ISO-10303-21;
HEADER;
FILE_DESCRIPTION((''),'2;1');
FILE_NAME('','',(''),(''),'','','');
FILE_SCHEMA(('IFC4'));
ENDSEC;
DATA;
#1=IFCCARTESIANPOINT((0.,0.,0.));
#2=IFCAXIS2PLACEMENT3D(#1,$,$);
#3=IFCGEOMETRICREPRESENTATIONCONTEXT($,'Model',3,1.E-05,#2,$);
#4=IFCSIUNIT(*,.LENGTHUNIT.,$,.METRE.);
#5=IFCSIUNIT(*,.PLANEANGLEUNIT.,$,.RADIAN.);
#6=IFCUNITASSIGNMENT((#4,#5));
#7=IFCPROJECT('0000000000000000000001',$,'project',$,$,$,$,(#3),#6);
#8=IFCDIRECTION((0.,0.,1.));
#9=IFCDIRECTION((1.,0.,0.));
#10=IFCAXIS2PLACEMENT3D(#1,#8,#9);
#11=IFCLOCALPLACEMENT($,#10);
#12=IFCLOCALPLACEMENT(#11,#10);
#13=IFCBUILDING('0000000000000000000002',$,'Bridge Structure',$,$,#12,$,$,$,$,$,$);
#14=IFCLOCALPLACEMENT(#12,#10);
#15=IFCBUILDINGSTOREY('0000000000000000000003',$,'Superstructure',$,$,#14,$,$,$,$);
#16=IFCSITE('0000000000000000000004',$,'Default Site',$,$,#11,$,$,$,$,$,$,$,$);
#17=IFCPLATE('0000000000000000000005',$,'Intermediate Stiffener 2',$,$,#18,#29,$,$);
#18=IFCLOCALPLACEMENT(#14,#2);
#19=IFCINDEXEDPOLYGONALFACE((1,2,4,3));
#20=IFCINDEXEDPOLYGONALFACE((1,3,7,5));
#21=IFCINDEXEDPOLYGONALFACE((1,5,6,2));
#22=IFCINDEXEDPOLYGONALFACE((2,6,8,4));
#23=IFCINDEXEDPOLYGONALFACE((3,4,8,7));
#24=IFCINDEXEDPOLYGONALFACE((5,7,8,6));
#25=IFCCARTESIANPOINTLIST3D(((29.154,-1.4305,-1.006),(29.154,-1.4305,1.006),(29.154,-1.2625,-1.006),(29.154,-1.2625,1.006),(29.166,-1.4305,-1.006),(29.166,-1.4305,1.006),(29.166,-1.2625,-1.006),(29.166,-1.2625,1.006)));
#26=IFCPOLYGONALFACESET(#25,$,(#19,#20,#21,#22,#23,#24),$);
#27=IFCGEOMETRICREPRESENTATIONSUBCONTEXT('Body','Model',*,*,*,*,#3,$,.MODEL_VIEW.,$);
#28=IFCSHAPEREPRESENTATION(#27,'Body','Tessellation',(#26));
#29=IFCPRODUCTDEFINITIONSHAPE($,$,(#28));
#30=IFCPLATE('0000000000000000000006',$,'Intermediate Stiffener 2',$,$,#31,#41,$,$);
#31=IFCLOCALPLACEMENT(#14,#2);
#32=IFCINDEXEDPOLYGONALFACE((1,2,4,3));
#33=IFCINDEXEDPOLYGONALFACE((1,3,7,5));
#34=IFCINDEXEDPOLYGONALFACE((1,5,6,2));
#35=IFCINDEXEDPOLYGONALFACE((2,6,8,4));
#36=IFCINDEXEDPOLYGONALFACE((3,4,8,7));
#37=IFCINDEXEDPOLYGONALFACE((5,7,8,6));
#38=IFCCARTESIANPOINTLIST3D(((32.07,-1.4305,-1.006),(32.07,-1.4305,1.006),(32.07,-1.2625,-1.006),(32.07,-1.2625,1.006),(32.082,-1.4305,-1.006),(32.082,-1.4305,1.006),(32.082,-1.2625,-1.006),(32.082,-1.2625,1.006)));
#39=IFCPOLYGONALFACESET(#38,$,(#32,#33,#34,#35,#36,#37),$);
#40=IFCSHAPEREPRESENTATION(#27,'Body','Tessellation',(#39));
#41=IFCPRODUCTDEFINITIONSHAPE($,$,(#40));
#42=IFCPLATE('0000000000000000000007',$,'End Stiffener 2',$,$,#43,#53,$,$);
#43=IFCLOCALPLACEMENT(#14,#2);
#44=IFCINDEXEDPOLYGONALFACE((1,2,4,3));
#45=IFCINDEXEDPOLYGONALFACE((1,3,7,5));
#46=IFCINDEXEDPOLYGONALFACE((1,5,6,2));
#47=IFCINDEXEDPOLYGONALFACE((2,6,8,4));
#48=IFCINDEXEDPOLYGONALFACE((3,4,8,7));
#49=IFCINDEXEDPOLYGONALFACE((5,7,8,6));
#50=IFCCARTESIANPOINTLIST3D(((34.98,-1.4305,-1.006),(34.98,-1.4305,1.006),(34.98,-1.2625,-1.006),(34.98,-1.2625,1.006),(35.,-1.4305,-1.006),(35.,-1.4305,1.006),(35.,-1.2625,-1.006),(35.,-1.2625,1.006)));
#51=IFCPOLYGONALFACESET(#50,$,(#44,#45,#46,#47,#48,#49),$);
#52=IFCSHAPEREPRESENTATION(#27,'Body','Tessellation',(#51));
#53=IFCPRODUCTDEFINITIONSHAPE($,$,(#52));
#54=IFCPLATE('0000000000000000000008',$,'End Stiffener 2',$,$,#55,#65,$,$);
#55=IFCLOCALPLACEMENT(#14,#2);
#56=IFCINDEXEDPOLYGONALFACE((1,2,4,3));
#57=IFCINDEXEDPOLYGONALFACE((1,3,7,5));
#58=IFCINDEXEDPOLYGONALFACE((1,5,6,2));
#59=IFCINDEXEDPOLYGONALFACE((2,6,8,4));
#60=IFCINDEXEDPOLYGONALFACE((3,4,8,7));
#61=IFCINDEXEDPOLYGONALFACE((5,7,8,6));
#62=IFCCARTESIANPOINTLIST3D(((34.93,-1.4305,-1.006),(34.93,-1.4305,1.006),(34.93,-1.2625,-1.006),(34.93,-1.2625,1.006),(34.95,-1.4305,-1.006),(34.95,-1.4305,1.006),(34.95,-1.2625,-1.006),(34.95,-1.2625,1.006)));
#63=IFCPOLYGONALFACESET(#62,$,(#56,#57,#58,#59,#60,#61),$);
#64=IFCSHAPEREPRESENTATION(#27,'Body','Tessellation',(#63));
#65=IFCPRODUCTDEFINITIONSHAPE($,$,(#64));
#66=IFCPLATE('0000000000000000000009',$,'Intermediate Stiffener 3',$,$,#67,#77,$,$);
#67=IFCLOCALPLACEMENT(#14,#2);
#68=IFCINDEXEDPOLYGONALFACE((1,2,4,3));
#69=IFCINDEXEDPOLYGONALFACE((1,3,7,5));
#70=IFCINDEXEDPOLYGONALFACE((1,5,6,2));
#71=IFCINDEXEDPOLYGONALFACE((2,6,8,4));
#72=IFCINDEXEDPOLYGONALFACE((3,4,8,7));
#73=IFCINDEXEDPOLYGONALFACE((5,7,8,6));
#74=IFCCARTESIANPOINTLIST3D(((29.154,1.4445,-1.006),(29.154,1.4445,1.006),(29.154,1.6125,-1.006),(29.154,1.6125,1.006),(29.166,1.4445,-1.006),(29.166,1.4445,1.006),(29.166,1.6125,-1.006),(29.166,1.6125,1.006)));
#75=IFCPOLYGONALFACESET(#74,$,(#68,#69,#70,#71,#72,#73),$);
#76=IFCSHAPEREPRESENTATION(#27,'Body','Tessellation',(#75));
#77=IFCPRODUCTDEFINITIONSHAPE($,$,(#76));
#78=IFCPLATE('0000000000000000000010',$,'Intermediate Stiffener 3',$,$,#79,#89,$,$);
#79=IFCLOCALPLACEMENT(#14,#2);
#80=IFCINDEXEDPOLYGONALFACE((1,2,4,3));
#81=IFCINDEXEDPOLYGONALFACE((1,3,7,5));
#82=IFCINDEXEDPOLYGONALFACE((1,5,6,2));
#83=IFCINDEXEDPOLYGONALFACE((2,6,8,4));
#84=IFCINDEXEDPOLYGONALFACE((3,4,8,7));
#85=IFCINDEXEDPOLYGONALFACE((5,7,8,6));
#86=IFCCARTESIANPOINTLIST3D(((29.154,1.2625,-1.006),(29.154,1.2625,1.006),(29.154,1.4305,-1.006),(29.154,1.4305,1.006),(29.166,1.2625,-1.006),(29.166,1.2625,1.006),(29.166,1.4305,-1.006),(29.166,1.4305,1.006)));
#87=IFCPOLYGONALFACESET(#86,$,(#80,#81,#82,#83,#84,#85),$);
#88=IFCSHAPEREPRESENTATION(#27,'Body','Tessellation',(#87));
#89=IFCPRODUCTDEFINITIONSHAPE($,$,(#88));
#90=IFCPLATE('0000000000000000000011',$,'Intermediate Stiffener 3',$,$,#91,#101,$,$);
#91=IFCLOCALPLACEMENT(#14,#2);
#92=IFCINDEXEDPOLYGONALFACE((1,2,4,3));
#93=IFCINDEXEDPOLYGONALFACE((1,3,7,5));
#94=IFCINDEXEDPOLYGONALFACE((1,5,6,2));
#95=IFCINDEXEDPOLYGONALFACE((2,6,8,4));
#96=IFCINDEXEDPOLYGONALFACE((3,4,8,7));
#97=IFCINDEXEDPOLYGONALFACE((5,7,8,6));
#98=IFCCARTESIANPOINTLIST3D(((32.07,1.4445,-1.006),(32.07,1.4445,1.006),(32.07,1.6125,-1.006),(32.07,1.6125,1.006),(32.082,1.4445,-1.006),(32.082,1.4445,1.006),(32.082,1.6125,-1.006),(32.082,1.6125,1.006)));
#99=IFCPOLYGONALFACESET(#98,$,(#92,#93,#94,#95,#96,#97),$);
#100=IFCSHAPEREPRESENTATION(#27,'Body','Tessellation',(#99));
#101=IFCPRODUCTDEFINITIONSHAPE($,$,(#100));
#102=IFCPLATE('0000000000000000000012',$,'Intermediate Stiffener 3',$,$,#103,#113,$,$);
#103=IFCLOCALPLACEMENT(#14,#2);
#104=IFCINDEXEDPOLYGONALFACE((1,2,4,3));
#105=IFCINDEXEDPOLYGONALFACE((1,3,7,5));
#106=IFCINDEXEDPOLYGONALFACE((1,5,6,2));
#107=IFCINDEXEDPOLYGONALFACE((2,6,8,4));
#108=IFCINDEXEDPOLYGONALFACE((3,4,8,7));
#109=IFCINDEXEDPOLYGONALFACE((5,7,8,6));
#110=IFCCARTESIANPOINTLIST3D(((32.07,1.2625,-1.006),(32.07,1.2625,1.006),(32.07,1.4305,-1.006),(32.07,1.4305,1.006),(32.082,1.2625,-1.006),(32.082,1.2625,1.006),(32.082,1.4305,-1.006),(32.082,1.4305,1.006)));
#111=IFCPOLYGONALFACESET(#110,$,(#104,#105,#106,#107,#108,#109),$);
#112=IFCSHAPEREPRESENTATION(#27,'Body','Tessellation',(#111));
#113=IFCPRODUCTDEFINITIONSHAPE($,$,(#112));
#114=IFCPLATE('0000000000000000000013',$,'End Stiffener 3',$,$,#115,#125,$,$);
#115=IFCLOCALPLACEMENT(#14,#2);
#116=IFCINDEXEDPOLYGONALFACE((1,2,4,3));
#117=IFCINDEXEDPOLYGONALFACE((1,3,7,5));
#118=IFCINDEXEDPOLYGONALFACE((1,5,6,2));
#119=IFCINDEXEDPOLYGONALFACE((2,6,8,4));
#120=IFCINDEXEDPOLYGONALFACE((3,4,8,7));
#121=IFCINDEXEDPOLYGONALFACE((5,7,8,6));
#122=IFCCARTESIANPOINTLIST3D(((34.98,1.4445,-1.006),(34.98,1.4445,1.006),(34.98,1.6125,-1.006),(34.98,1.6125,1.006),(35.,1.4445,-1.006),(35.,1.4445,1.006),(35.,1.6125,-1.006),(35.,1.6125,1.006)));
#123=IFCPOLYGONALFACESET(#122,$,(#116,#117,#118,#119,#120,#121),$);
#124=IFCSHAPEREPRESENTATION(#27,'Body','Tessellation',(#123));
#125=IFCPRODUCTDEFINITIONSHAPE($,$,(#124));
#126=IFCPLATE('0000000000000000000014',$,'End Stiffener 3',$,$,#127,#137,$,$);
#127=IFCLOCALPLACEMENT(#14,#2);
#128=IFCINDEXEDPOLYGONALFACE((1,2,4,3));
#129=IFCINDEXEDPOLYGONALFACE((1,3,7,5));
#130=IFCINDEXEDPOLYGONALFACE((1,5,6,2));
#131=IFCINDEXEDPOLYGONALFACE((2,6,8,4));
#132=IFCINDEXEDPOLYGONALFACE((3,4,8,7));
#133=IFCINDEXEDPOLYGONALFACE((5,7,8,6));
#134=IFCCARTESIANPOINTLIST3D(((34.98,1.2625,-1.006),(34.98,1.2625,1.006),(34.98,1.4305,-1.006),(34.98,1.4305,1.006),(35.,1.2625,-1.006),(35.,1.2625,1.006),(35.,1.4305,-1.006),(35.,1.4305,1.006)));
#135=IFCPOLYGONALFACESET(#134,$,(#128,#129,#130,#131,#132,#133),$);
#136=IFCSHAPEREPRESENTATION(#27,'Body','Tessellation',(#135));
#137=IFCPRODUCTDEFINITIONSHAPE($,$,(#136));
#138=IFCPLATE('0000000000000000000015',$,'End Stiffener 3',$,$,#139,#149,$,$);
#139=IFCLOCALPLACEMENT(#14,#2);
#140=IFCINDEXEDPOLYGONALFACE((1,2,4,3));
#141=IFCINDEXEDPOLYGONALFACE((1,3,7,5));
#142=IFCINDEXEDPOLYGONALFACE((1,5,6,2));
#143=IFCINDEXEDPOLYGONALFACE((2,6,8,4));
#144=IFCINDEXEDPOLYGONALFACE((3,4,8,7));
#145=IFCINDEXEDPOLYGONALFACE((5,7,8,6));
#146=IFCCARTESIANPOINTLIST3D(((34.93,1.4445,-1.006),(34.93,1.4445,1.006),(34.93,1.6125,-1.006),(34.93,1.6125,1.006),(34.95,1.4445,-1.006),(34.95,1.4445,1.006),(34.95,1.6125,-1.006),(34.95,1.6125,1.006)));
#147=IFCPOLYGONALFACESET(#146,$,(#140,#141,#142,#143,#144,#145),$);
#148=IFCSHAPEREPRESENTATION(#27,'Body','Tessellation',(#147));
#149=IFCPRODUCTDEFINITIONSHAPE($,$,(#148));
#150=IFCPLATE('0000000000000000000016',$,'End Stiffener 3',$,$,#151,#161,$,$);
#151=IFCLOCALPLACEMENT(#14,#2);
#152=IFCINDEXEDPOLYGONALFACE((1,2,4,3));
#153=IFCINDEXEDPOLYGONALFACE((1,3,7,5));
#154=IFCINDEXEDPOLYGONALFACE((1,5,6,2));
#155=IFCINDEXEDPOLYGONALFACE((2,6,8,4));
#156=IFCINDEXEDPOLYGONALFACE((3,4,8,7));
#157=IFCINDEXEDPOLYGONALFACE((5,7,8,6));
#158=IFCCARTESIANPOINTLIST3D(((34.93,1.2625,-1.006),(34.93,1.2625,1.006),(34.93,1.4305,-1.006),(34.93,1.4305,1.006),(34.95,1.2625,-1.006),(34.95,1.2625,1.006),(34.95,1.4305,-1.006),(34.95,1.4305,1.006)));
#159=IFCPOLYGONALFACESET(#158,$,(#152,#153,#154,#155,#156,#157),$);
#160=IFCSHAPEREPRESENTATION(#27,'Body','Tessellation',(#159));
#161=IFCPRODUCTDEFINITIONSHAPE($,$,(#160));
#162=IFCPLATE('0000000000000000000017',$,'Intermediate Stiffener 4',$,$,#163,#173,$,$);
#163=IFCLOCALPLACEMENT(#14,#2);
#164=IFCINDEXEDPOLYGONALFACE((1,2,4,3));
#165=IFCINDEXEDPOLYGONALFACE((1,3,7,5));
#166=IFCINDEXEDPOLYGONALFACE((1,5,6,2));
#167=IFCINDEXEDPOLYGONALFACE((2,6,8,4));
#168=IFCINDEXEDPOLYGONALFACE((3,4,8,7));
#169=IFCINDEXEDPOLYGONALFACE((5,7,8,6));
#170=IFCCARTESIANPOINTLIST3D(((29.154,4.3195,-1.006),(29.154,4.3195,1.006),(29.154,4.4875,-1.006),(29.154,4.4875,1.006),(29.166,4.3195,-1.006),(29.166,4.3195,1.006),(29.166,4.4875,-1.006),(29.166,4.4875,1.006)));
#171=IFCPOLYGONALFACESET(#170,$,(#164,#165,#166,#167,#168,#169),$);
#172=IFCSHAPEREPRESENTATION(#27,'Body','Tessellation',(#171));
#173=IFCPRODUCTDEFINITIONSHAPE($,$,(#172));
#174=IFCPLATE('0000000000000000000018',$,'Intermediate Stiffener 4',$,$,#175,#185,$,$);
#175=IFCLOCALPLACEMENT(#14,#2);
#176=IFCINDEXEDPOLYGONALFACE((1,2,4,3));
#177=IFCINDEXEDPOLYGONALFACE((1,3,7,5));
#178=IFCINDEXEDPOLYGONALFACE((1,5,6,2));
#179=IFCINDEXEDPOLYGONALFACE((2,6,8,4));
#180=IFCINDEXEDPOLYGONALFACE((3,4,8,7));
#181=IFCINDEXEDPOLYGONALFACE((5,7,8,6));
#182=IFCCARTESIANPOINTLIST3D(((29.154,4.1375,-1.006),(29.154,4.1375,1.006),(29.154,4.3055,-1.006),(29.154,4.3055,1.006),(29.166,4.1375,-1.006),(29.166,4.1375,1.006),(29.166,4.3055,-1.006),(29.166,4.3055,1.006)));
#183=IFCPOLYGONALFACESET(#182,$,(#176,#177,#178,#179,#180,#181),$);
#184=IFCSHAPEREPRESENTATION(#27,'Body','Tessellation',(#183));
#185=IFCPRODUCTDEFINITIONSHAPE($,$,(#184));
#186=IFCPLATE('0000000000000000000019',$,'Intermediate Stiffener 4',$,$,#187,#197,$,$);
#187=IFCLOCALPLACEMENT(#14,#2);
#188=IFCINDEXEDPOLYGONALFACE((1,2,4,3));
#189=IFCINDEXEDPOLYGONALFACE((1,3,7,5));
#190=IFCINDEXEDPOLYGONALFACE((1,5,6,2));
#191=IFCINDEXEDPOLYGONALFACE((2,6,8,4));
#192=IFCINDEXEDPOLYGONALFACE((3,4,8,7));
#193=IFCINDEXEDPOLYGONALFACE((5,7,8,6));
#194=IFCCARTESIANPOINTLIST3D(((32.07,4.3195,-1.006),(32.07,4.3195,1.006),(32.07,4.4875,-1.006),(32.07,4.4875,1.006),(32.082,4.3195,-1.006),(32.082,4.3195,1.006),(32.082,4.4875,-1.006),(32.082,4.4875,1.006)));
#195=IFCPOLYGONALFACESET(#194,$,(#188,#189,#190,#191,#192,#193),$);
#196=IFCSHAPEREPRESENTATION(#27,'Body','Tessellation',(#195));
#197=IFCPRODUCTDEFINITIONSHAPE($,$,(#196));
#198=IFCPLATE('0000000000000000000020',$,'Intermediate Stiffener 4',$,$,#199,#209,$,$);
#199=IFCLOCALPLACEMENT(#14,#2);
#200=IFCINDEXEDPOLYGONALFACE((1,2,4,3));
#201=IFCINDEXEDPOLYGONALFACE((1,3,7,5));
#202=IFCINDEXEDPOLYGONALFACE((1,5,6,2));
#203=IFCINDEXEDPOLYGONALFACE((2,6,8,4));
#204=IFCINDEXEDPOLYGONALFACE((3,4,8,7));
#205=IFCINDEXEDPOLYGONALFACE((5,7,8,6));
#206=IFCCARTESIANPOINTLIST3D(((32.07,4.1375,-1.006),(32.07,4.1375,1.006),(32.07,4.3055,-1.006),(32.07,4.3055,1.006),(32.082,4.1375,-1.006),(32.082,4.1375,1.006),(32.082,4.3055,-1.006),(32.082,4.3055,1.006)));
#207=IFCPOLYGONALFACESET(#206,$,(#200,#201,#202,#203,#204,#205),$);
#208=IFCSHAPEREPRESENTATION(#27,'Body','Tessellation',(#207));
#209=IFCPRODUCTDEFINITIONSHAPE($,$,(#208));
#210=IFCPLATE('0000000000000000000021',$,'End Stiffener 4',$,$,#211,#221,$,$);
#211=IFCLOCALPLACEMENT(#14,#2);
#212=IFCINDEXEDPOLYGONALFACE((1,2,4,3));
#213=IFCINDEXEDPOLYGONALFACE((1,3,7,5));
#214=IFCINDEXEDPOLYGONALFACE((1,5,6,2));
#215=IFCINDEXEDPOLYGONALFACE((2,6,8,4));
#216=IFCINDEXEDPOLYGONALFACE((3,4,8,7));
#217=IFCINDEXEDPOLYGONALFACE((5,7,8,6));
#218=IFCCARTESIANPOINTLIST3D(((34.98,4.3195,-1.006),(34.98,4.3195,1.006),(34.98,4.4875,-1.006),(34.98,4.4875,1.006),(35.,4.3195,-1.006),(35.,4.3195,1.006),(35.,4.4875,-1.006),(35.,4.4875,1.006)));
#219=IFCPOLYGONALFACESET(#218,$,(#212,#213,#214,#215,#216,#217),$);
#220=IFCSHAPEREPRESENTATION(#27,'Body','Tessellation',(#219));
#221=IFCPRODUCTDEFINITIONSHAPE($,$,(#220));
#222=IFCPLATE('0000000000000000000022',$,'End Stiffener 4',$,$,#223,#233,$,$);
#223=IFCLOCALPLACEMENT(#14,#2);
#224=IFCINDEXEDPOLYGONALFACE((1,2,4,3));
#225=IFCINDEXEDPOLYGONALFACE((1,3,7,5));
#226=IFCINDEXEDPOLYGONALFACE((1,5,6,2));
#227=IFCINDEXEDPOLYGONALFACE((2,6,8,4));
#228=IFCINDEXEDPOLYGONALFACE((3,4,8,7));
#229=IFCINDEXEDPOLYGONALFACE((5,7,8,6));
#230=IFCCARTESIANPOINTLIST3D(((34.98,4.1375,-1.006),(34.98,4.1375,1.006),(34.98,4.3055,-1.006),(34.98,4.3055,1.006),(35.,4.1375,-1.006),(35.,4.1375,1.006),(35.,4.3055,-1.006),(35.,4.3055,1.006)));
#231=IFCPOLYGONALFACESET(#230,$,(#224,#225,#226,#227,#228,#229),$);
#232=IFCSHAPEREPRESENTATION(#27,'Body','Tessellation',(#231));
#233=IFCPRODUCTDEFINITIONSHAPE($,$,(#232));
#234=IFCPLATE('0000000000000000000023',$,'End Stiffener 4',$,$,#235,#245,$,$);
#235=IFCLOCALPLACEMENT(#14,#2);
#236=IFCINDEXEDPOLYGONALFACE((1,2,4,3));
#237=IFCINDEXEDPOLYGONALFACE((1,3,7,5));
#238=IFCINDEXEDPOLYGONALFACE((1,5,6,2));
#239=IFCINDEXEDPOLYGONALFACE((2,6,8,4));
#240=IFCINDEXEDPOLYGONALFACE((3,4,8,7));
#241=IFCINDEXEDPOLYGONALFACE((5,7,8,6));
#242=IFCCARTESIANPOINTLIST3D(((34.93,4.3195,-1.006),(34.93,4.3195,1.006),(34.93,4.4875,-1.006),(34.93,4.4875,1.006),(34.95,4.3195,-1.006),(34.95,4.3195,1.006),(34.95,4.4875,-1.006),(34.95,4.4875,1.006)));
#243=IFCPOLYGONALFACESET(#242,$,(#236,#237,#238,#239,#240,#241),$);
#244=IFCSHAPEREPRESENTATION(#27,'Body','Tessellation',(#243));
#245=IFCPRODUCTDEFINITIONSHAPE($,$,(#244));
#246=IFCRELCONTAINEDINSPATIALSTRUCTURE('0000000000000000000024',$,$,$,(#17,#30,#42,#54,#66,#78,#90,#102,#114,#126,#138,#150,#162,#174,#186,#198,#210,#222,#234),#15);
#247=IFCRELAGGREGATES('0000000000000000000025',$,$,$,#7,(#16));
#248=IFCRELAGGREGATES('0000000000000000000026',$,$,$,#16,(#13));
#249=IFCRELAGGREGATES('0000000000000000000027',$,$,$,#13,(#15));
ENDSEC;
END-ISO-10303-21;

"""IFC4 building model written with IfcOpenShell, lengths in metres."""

from ifc_helpers import new_model, si_unit, frame, origin, origin_with_axes, origin_2d_with_axis, place, context, subcontext, project, spatial, rectangle, extrude, element, save


model = new_model("IFC4")

# Units and contexts
model_context = context("Model", 3, precision=1e-05, world=origin())
body_context = subcontext(model_context, "Body", "Model", "MODEL_VIEW")
ifc_project = project(units=[si_unit("LENGTHUNIT", "METRE"), si_unit("PLANEANGLEUNIT", "RADIAN")], contexts=[model_context])

# Site, building, storey
site_placement = place(None, origin_with_axes())
site = spatial("IfcSite", under=ifc_project, at=site_placement, Name="Default Site")
building_placement = place(site_placement, origin_with_axes())
building = spatial("IfcBuilding", under=site, at=building_placement, Name="Bridge Structure")
storey_placement = place(building_placement, origin_with_axes())
storey = spatial("IfcBuildingStorey", under=building, at=storey_placement, Name="Superstructure")

# Plates
for number, where, z_axis, x_axis, name in (
    (1, (29.16, -1.3465, -1.006), (0.0, 0.0, 1.0), (1.0, 0.0, 0.0), "Intermediate Stiffener 2"),
    (2, (32.076, -1.3465, -1.006), (0.0, 0.0, 1.0), (1.0, 0.0, 0.0), "Intermediate Stiffener 2"),
):
    element("IfcPlate", number, at=place(storey_placement, frame(where, z_axis=z_axis, x_axis=x_axis)), inside=storey, Name=name, context=body_context, shape_type="SweptSolid", body=[
        extrude(rectangle(XDim=0.012, YDim=0.168, at=origin_2d_with_axis()), origin_with_axes(), (0.0, 0.0, 1.0), 2.012),
    ])
for number, where, z_axis, x_axis, name in (
    (3, (34.99, -1.3465, -1.006), (0.0, 0.0, 1.0), (1.0, 0.0, 0.0), "End Stiffener 2"),
    (4, (34.94, -1.3465, -1.006), (0.0, 0.0, 1.0), (1.0, 0.0, 0.0), "End Stiffener 2"),
):
    element("IfcPlate", number, at=place(storey_placement, frame(where, z_axis=z_axis, x_axis=x_axis)), inside=storey, Name=name, context=body_context, shape_type="SweptSolid", body=[
        extrude(rectangle(XDim=0.02, YDim=0.168, at=origin_2d_with_axis()), origin_with_axes(), (0.0, 0.0, 1.0), 2.012),
    ])
for number, where, z_axis, x_axis, name in (
    (5, (29.16, 1.5285, -1.006), (0.0, 0.0, 1.0), (1.0, 0.0, 0.0), "Intermediate Stiffener 3"),
    (6, (29.16, 1.3465, -1.006), (0.0, 0.0, 1.0), (1.0, 0.0, 0.0), "Intermediate Stiffener 3"),
    (7, (32.076, 1.5285, -1.006), (0.0, 0.0, 1.0), (1.0, 0.0, 0.0), "Intermediate Stiffener 3"),
    (8, (32.076, 1.3465, -1.006), (0.0, 0.0, 1.0), (1.0, 0.0, 0.0), "Intermediate Stiffener 3"),
):
    element("IfcPlate", number, at=place(storey_placement, frame(where, z_axis=z_axis, x_axis=x_axis)), inside=storey, Name=name, context=body_context, shape_type="SweptSolid", body=[
        extrude(rectangle(XDim=0.012, YDim=0.168, at=origin_2d_with_axis()), origin_with_axes(), (0.0, 0.0, 1.0), 2.012),
    ])
for number, where, z_axis, x_axis, name in (
    (9, (34.99, 1.5285, -1.006), (0.0, 0.0, 1.0), (1.0, 0.0, 0.0), "End Stiffener 3"),
    (10, (34.99, 1.3465, -1.006), (0.0, 0.0, 1.0), (1.0, 0.0, 0.0), "End Stiffener 3"),
    (11, (34.94, 1.5285, -1.006), (0.0, 0.0, 1.0), (1.0, 0.0, 0.0), "End Stiffener 3"),
    (12, (34.94, 1.3465, -1.006), (0.0, 0.0, 1.0), (1.0, 0.0, 0.0), "End Stiffener 3"),
):
    element("IfcPlate", number, at=place(storey_placement, frame(where, z_axis=z_axis, x_axis=x_axis)), inside=storey, Name=name, context=body_context, shape_type="SweptSolid", body=[
        extrude(rectangle(XDim=0.02, YDim=0.168, at=origin_2d_with_axis()), origin_with_axes(), (0.0, 0.0, 1.0), 2.012),
    ])
for number, where, z_axis, x_axis, name in (
    (13, (29.16, 4.4035, -1.006), (0.0, 0.0, 1.0), (1.0, 0.0, 0.0), "Intermediate Stiffener 4"),
    (14, (29.16, 4.2215, -1.006), (0.0, 0.0, 1.0), (1.0, 0.0, 0.0), "Intermediate Stiffener 4"),
    (15, (32.076, 4.4035, -1.006), (0.0, 0.0, 1.0), (1.0, 0.0, 0.0), "Intermediate Stiffener 4"),
    (16, (32.076, 4.2215, -1.006), (0.0, 0.0, 1.0), (1.0, 0.0, 0.0), "Intermediate Stiffener 4"),
):
    element("IfcPlate", number, at=place(storey_placement, frame(where, z_axis=z_axis, x_axis=x_axis)), inside=storey, Name=name, context=body_context, shape_type="SweptSolid", body=[
        extrude(rectangle(XDim=0.012, YDim=0.168, at=origin_2d_with_axis()), origin_with_axes(), (0.0, 0.0, 1.0), 2.012),
    ])
for number, where, z_axis, x_axis, name in (
    (17, (34.99, 4.4035, -1.006), (0.0, 0.0, 1.0), (1.0, 0.0, 0.0), "End Stiffener 4"),
    (18, (34.99, 4.2215, -1.006), (0.0, 0.0, 1.0), (1.0, 0.0, 0.0), "End Stiffener 4"),
    (19, (34.94, 4.4035, -1.006), (0.0, 0.0, 1.0), (1.0, 0.0, 0.0), "End Stiffener 4"),
):
    element("IfcPlate", number, at=place(storey_placement, frame(where, z_axis=z_axis, x_axis=x_axis)), inside=storey, Name=name, context=body_context, shape_type="SweptSolid", body=[
        extrude(rectangle(XDim=0.02, YDim=0.168, at=origin_2d_with_axis()), origin_with_axes(), (0.0, 0.0, 1.0), 2.012),
    ])

save(model, "model.ifc")
